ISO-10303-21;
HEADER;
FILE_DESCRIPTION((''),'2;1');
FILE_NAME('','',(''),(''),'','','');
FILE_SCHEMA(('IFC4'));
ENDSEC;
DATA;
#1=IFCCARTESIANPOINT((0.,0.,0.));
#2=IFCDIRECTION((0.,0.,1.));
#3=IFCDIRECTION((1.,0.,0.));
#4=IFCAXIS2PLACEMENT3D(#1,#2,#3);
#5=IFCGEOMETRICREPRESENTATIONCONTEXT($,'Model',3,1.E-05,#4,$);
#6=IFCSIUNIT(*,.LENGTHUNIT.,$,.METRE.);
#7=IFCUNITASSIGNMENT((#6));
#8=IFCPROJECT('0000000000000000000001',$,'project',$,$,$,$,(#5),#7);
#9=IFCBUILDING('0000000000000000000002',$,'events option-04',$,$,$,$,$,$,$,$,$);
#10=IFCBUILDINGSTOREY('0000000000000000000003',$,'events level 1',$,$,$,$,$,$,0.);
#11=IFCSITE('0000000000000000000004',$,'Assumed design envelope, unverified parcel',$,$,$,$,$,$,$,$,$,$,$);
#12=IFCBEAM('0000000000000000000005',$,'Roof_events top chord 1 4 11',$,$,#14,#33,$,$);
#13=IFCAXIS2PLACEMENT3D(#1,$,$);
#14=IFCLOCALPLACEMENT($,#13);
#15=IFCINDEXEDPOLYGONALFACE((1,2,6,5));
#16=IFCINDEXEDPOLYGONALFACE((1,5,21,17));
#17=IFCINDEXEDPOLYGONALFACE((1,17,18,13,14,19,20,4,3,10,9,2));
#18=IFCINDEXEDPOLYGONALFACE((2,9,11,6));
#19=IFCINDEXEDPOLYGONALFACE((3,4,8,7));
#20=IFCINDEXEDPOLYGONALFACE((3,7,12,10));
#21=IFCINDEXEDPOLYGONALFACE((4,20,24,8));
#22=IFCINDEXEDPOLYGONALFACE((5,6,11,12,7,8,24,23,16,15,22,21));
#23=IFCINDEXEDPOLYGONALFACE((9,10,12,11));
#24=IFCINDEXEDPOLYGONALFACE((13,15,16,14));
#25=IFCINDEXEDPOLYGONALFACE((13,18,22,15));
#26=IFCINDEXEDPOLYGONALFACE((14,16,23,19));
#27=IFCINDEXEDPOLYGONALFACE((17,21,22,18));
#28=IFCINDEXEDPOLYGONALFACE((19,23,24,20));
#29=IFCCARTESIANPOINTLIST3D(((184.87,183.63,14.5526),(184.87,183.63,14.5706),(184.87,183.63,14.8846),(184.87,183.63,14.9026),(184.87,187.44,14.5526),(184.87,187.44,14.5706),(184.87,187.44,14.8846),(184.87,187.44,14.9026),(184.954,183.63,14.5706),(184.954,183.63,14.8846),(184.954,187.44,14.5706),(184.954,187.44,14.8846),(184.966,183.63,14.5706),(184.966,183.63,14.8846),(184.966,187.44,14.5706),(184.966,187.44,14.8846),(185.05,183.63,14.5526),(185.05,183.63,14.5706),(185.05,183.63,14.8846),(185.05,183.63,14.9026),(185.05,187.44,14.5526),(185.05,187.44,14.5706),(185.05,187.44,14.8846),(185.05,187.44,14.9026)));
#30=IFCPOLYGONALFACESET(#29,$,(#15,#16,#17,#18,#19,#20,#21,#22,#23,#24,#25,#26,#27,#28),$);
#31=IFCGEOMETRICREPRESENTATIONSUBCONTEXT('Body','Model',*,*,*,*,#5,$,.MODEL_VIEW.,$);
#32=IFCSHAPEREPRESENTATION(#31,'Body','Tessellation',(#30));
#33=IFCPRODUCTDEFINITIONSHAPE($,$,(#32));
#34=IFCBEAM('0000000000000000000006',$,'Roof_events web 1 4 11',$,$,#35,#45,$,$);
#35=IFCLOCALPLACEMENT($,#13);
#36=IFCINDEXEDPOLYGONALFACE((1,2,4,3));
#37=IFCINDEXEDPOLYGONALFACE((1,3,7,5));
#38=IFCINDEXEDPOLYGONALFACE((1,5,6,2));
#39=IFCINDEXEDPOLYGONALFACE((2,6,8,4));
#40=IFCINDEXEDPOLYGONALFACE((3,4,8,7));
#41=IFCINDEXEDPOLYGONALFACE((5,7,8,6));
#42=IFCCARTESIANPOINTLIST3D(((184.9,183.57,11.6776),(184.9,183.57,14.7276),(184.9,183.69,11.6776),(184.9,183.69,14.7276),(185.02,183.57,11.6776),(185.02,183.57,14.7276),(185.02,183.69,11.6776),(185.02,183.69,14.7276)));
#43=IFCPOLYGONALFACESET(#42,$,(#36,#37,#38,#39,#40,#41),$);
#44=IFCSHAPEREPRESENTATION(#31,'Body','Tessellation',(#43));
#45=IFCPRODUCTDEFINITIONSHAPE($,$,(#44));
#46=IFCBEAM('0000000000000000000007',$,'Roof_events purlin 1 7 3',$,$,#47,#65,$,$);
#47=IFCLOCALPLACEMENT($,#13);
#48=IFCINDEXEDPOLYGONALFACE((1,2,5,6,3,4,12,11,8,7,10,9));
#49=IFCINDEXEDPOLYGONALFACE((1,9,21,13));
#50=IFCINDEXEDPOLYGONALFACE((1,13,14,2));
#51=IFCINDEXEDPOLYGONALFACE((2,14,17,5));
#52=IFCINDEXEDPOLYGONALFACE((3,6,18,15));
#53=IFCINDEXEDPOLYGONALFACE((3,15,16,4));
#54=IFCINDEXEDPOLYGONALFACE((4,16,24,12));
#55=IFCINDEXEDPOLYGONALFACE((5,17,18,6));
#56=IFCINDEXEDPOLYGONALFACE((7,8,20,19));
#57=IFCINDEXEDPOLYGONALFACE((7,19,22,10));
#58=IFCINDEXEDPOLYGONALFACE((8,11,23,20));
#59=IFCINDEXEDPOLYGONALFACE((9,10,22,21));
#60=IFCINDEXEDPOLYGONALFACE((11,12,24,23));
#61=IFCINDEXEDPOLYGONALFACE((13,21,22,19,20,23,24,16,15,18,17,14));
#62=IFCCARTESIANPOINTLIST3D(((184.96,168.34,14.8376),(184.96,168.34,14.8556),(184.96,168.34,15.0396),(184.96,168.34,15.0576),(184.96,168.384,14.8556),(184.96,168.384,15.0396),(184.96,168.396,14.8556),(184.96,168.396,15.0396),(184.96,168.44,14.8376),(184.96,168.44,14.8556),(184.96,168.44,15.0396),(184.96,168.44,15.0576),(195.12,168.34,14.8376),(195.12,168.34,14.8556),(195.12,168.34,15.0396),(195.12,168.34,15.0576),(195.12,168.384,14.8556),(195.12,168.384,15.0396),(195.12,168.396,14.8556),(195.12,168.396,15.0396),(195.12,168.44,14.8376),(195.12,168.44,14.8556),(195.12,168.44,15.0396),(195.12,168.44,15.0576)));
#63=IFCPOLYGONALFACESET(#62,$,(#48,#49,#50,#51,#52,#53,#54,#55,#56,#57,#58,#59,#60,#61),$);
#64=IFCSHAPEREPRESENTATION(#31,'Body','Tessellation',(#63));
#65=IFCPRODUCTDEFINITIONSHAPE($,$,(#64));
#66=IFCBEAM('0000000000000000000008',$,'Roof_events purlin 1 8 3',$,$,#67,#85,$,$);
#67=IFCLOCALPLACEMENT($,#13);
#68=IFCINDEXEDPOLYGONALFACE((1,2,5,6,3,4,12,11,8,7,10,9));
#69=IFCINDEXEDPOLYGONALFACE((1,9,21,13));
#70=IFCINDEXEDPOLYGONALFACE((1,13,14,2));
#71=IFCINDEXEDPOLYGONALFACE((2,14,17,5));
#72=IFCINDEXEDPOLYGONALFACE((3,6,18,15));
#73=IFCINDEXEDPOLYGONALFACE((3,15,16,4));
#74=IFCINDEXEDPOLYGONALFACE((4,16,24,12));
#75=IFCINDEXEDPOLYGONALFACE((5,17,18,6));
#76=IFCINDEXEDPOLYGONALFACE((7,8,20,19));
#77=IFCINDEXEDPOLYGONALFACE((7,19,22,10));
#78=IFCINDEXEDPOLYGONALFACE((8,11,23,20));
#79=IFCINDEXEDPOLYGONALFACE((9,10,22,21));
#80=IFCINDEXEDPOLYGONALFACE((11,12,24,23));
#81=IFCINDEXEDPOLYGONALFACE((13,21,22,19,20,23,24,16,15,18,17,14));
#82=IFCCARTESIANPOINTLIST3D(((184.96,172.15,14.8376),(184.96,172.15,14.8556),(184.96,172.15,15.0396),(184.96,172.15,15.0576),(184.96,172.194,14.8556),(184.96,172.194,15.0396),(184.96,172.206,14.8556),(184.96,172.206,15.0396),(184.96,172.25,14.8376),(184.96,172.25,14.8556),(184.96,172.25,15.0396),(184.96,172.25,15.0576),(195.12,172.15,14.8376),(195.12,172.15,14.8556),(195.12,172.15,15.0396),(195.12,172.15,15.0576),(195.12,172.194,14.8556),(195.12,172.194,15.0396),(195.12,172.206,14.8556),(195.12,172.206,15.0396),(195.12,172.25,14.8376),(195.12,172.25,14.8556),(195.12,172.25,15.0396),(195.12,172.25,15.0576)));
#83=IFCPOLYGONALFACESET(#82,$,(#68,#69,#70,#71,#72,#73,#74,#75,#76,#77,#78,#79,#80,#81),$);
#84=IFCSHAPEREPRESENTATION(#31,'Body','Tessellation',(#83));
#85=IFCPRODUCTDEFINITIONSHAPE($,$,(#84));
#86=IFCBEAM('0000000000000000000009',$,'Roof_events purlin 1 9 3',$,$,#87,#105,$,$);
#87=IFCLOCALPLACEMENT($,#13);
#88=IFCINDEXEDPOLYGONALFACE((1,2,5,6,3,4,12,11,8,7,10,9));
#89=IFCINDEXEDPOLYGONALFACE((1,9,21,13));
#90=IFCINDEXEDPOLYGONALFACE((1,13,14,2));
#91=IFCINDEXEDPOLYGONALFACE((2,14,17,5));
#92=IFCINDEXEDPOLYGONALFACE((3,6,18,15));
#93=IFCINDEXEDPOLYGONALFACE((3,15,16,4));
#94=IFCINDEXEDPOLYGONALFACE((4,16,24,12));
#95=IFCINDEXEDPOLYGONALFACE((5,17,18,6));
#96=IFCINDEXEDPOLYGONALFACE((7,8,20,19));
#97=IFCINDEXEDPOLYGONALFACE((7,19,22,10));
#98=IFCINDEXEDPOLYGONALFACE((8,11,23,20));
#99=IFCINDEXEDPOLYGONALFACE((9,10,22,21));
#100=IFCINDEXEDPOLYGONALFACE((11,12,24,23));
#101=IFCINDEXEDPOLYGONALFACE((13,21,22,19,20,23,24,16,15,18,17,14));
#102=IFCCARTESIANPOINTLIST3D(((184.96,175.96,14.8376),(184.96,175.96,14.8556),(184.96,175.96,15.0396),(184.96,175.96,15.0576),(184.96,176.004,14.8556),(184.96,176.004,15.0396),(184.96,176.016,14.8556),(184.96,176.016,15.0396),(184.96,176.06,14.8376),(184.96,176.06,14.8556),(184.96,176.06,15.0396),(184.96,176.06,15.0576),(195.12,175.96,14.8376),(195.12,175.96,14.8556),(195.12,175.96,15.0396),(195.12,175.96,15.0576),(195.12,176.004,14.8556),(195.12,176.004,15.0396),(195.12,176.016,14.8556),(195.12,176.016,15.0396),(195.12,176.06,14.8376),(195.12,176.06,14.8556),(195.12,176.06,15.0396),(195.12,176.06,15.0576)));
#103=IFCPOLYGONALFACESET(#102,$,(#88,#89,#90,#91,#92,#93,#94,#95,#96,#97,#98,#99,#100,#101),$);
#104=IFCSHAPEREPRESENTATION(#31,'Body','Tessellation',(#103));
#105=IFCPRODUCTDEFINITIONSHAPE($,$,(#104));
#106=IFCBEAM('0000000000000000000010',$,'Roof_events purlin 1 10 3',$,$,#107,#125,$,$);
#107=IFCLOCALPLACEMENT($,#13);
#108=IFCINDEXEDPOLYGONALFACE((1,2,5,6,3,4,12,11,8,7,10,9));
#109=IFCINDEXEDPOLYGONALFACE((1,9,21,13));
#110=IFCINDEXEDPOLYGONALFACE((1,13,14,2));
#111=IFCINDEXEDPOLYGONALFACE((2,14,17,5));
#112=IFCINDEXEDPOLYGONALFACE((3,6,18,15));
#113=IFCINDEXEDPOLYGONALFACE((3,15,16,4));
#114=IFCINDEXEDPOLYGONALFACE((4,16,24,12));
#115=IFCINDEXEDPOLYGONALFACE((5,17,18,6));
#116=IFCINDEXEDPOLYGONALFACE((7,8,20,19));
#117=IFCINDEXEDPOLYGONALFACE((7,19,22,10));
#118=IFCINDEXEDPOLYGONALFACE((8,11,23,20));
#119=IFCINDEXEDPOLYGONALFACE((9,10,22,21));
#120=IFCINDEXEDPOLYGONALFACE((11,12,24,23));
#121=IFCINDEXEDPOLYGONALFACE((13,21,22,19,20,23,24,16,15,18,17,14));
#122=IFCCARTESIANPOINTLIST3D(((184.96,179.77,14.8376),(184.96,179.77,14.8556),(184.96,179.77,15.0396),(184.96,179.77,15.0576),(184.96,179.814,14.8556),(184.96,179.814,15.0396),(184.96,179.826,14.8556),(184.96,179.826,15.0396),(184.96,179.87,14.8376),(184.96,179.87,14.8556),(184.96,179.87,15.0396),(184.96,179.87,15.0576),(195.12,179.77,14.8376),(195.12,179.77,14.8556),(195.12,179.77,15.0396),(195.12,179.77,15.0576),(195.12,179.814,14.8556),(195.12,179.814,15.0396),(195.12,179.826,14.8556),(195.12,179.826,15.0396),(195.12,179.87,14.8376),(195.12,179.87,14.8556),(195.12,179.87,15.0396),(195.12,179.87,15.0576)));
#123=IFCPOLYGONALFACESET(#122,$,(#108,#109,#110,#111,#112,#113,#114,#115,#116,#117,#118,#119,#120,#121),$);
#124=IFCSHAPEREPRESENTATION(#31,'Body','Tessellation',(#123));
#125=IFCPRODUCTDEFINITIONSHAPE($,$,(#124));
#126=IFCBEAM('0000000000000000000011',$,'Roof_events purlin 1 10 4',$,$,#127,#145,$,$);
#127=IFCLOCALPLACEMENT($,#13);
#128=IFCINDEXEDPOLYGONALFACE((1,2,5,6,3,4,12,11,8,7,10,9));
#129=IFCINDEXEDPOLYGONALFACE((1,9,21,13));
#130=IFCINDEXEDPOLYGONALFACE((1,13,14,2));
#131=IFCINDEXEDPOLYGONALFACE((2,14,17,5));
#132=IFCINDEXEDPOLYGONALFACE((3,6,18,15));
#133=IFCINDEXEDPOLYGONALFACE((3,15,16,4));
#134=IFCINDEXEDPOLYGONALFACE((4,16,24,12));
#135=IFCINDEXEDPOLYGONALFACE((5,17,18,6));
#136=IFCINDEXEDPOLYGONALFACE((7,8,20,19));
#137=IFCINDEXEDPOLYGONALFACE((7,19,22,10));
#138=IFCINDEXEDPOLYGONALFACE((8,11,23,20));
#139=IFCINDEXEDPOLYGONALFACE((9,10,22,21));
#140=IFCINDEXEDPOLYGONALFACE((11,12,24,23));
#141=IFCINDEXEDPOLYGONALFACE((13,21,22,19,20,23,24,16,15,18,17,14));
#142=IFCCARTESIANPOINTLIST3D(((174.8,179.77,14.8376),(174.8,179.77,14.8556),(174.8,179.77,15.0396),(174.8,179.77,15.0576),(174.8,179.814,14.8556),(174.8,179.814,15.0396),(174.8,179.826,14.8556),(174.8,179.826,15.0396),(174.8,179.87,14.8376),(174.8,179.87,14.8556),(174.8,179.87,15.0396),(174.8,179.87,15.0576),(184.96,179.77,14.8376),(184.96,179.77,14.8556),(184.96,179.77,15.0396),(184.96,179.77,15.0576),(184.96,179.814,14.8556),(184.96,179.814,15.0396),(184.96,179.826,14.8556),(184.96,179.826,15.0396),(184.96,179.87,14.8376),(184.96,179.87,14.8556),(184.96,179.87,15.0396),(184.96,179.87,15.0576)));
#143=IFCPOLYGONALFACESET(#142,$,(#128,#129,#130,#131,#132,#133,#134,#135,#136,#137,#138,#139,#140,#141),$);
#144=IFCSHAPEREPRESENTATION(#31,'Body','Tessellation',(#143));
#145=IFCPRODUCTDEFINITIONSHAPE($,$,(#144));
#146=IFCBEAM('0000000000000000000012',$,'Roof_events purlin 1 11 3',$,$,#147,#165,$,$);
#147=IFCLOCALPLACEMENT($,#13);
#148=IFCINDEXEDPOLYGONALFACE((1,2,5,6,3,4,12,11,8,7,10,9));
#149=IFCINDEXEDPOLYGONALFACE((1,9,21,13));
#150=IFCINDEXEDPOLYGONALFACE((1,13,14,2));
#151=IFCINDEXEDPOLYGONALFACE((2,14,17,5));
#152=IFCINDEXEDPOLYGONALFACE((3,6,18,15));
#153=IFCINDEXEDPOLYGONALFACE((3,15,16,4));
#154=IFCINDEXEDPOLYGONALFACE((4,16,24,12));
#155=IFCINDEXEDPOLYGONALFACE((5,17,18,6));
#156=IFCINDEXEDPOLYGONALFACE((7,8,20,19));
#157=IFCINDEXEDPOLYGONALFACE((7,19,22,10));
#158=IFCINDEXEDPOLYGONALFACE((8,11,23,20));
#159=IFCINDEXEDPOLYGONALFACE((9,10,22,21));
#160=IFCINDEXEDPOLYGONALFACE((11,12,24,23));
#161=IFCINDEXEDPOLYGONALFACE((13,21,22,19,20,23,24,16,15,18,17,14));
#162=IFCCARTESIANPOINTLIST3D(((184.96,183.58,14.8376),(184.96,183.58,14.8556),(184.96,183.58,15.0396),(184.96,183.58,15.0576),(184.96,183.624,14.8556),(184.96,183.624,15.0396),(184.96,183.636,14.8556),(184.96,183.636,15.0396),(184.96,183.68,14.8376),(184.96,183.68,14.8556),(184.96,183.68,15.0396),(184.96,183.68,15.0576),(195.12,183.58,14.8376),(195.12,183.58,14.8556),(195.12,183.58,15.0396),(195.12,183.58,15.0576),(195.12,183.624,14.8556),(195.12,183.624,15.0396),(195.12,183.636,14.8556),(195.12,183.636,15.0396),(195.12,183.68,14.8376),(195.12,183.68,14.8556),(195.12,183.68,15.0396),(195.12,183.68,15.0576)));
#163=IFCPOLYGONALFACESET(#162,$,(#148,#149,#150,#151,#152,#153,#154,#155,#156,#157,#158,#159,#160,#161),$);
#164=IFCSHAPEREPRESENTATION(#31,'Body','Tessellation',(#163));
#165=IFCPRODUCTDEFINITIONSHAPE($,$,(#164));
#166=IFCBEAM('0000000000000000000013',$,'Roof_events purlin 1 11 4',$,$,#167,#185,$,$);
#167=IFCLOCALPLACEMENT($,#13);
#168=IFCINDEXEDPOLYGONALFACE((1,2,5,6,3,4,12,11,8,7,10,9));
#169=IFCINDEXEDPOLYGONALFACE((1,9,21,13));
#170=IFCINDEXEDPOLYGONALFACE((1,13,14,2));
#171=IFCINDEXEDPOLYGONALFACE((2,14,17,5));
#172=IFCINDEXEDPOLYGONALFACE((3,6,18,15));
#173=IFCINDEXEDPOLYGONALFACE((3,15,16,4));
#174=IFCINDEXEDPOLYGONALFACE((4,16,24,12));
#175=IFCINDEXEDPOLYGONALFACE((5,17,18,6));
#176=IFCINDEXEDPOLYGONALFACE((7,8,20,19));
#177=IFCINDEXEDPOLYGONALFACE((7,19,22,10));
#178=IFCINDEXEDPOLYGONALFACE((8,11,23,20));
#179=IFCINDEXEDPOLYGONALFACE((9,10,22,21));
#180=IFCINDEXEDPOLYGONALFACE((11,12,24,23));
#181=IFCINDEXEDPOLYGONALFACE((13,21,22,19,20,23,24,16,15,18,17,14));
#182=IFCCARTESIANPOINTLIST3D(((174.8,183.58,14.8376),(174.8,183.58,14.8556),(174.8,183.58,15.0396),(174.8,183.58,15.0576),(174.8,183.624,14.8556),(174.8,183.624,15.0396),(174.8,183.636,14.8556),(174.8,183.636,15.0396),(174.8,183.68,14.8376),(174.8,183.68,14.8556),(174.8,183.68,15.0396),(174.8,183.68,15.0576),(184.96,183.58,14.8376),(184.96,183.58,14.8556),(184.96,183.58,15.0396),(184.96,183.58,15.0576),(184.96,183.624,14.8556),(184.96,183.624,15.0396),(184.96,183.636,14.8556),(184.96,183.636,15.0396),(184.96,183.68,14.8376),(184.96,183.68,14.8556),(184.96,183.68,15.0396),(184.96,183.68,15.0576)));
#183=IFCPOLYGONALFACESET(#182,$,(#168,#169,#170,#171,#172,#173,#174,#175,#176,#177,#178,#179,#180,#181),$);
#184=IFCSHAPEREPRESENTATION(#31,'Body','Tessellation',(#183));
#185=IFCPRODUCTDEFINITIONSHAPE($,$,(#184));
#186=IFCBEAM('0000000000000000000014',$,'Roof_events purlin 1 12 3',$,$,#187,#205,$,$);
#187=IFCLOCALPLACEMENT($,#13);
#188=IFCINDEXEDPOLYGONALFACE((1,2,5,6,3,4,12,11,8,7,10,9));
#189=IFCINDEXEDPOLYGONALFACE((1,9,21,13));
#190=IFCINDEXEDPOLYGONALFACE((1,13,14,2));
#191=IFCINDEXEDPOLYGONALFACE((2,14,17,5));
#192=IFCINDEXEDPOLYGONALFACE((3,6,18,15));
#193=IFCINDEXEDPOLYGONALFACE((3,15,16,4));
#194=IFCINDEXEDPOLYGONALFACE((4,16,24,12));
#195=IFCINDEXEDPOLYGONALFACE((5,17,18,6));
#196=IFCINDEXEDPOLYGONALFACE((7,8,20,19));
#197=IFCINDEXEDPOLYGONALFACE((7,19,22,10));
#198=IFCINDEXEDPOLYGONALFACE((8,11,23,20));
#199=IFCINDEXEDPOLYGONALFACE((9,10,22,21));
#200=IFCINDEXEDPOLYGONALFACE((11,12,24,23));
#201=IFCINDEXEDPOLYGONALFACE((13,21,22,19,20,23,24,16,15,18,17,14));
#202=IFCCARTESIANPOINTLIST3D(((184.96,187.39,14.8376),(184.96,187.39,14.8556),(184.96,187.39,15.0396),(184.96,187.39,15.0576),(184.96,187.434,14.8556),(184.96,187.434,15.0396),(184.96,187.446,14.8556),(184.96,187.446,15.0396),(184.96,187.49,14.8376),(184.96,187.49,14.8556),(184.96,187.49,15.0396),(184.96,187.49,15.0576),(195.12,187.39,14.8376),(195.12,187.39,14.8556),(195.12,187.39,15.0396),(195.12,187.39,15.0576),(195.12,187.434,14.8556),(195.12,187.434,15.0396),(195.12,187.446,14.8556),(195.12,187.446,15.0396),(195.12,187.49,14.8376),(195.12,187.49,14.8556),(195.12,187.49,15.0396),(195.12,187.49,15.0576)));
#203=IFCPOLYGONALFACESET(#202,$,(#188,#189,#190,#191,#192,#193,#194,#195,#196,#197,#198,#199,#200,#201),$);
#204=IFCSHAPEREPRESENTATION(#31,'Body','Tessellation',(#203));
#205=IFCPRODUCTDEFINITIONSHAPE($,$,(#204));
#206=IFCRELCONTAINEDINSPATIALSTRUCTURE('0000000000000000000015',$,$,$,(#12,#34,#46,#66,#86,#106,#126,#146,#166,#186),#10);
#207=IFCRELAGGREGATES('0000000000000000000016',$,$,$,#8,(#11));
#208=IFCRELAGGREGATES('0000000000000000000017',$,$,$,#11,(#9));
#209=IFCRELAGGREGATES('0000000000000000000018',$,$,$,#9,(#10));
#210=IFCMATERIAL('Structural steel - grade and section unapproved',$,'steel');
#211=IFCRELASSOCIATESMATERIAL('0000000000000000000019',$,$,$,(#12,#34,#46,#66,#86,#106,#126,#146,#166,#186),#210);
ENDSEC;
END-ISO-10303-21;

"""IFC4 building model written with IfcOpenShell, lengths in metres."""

from ifc_helpers import new_model, si_unit, frame, origin_with_axes, place, context, subcontext, project, spatial, rectangle, i_section, extrude, material, element, save


model = new_model("IFC4")

# Units and contexts
model_context = context("Model", 3, precision=1e-05, world=origin_with_axes())
body_context = subcontext(model_context, "Body", "Model", "MODEL_VIEW")
ifc_project = project(units=[si_unit("LENGTHUNIT", "METRE")], contexts=[model_context])

# Site, building, storey
site = spatial("IfcSite", under=ifc_project, Name="Assumed design envelope, unverified parcel")
building = spatial("IfcBuilding", under=site, Name="events option-04")
storey = spatial("IfcBuildingStorey", under=building, Name="events level 1", Elevation=0.0)

# Shared definitions
ifc_material_1 = material(Name="Structural steel - grade and section unapproved", Category="steel")

# Beams
beam_1_placement = place(None, frame((184.96, 183.63, 14.7276), z_axis=(0.0, 1.0, 0.0), x_axis=(-1.0, 0.0, 0.0)))
element("IfcBeam", 1, at=beam_1_placement, inside=storey, material=ifc_material_1, Name="Roof_events top chord 1 4 11", context=body_context, shape_type="SweptSolid", body=[
    extrude(i_section(OverallWidth=0.18, OverallDepth=0.35, WebThickness=0.012, FlangeThickness=0.018, FilletRadius=0.0), origin_with_axes(), (0.0, 0.0, 1.0), 3.81),
])
beam_2_placement = place(None, frame((184.96, 183.63, 11.6776), z_axis=(0.0, 0.0, 1.0), x_axis=(-1.0, 0.0, 0.0)))
element("IfcBeam", 2, at=beam_2_placement, inside=storey, material=ifc_material_1, Name="Roof_events web 1 4 11", context=body_context, shape_type="SweptSolid", body=[
    extrude(rectangle(XDim=0.12, YDim=0.12), origin_with_axes(), (0.0, 0.0, 1.0), 3.05),
])
for number, where, z_axis, x_axis, name in (
    (3, (195.12, 168.39, 14.9476), (-1.0, 0.0, 0.0), (0.0, -1.0, 0.0), "Roof_events purlin 1 7 3"),
    (4, (195.12, 172.2, 14.9476), (-1.0, 0.0, 0.0), (0.0, -1.0, 0.0), "Roof_events purlin 1 8 3"),
    (5, (195.12, 176.01, 14.9476), (-1.0, 0.0, 0.0), (0.0, -1.0, 0.0), "Roof_events purlin 1 9 3"),
    (6, (195.12, 179.82, 14.9476), (-1.0, 0.0, 0.0), (0.0, -1.0, 0.0), "Roof_events purlin 1 10 3"),
):
    element("IfcBeam", number, at=place(None, frame(where, z_axis=z_axis, x_axis=x_axis)), inside=storey, material=ifc_material_1, Name=name, context=body_context, shape_type="SweptSolid", body=[
        extrude(i_section(OverallWidth=0.1, OverallDepth=0.22, WebThickness=0.012, FlangeThickness=0.018, FilletRadius=0.0), origin_with_axes(), (0.0, 0.0, 1.0), 10.16),
    ])
beam_3_placement = place(None, frame((184.96, 179.82, 14.9476), z_axis=(-1.0, 0.0, 0.0), x_axis=(0.0, -1.0, 0.0)))
element("IfcBeam", 7, at=beam_3_placement, inside=storey, material=ifc_material_1, Name="Roof_events purlin 1 10 4", context=body_context, shape_type="SweptSolid", body=[
    extrude(i_section(OverallWidth=0.1, OverallDepth=0.22, WebThickness=0.012, FlangeThickness=0.018, FilletRadius=0.0), origin_with_axes(), (0.0, 0.0, 1.0), 10.16),
])
beam_4_placement = place(None, frame((195.12, 183.63, 14.9476), z_axis=(-1.0, 0.0, 0.0), x_axis=(0.0, -1.0, 0.0)))
element("IfcBeam", 8, at=beam_4_placement, inside=storey, material=ifc_material_1, Name="Roof_events purlin 1 11 3", context=body_context, shape_type="SweptSolid", body=[
    extrude(i_section(OverallWidth=0.1, OverallDepth=0.22, WebThickness=0.012, FlangeThickness=0.018, FilletRadius=0.0), origin_with_axes(), (0.0, 0.0, 1.0), 10.16),
])
beam_5_placement = place(None, frame((184.96, 183.63, 14.9476), z_axis=(-1.0, 0.0, 0.0), x_axis=(0.0, -1.0, 0.0)))
element("IfcBeam", 9, at=beam_5_placement, inside=storey, material=ifc_material_1, Name="Roof_events purlin 1 11 4", context=body_context, shape_type="SweptSolid", body=[
    extrude(i_section(OverallWidth=0.1, OverallDepth=0.22, WebThickness=0.012, FlangeThickness=0.018, FilletRadius=0.0), origin_with_axes(), (0.0, 0.0, 1.0), 10.16),
])
beam_6_placement = place(None, frame((195.12, 187.44, 14.9476), z_axis=(-1.0, 0.0, 0.0), x_axis=(0.0, -1.0, 0.0)))
element("IfcBeam", 10, at=beam_6_placement, inside=storey, material=ifc_material_1, Name="Roof_events purlin 1 12 3", context=body_context, shape_type="SweptSolid", body=[
    extrude(i_section(OverallWidth=0.1, OverallDepth=0.22, WebThickness=0.012, FlangeThickness=0.018, FilletRadius=0.0), origin_with_axes(), (0.0, 0.0, 1.0), 10.16),
])

save(model, "model.ifc")
